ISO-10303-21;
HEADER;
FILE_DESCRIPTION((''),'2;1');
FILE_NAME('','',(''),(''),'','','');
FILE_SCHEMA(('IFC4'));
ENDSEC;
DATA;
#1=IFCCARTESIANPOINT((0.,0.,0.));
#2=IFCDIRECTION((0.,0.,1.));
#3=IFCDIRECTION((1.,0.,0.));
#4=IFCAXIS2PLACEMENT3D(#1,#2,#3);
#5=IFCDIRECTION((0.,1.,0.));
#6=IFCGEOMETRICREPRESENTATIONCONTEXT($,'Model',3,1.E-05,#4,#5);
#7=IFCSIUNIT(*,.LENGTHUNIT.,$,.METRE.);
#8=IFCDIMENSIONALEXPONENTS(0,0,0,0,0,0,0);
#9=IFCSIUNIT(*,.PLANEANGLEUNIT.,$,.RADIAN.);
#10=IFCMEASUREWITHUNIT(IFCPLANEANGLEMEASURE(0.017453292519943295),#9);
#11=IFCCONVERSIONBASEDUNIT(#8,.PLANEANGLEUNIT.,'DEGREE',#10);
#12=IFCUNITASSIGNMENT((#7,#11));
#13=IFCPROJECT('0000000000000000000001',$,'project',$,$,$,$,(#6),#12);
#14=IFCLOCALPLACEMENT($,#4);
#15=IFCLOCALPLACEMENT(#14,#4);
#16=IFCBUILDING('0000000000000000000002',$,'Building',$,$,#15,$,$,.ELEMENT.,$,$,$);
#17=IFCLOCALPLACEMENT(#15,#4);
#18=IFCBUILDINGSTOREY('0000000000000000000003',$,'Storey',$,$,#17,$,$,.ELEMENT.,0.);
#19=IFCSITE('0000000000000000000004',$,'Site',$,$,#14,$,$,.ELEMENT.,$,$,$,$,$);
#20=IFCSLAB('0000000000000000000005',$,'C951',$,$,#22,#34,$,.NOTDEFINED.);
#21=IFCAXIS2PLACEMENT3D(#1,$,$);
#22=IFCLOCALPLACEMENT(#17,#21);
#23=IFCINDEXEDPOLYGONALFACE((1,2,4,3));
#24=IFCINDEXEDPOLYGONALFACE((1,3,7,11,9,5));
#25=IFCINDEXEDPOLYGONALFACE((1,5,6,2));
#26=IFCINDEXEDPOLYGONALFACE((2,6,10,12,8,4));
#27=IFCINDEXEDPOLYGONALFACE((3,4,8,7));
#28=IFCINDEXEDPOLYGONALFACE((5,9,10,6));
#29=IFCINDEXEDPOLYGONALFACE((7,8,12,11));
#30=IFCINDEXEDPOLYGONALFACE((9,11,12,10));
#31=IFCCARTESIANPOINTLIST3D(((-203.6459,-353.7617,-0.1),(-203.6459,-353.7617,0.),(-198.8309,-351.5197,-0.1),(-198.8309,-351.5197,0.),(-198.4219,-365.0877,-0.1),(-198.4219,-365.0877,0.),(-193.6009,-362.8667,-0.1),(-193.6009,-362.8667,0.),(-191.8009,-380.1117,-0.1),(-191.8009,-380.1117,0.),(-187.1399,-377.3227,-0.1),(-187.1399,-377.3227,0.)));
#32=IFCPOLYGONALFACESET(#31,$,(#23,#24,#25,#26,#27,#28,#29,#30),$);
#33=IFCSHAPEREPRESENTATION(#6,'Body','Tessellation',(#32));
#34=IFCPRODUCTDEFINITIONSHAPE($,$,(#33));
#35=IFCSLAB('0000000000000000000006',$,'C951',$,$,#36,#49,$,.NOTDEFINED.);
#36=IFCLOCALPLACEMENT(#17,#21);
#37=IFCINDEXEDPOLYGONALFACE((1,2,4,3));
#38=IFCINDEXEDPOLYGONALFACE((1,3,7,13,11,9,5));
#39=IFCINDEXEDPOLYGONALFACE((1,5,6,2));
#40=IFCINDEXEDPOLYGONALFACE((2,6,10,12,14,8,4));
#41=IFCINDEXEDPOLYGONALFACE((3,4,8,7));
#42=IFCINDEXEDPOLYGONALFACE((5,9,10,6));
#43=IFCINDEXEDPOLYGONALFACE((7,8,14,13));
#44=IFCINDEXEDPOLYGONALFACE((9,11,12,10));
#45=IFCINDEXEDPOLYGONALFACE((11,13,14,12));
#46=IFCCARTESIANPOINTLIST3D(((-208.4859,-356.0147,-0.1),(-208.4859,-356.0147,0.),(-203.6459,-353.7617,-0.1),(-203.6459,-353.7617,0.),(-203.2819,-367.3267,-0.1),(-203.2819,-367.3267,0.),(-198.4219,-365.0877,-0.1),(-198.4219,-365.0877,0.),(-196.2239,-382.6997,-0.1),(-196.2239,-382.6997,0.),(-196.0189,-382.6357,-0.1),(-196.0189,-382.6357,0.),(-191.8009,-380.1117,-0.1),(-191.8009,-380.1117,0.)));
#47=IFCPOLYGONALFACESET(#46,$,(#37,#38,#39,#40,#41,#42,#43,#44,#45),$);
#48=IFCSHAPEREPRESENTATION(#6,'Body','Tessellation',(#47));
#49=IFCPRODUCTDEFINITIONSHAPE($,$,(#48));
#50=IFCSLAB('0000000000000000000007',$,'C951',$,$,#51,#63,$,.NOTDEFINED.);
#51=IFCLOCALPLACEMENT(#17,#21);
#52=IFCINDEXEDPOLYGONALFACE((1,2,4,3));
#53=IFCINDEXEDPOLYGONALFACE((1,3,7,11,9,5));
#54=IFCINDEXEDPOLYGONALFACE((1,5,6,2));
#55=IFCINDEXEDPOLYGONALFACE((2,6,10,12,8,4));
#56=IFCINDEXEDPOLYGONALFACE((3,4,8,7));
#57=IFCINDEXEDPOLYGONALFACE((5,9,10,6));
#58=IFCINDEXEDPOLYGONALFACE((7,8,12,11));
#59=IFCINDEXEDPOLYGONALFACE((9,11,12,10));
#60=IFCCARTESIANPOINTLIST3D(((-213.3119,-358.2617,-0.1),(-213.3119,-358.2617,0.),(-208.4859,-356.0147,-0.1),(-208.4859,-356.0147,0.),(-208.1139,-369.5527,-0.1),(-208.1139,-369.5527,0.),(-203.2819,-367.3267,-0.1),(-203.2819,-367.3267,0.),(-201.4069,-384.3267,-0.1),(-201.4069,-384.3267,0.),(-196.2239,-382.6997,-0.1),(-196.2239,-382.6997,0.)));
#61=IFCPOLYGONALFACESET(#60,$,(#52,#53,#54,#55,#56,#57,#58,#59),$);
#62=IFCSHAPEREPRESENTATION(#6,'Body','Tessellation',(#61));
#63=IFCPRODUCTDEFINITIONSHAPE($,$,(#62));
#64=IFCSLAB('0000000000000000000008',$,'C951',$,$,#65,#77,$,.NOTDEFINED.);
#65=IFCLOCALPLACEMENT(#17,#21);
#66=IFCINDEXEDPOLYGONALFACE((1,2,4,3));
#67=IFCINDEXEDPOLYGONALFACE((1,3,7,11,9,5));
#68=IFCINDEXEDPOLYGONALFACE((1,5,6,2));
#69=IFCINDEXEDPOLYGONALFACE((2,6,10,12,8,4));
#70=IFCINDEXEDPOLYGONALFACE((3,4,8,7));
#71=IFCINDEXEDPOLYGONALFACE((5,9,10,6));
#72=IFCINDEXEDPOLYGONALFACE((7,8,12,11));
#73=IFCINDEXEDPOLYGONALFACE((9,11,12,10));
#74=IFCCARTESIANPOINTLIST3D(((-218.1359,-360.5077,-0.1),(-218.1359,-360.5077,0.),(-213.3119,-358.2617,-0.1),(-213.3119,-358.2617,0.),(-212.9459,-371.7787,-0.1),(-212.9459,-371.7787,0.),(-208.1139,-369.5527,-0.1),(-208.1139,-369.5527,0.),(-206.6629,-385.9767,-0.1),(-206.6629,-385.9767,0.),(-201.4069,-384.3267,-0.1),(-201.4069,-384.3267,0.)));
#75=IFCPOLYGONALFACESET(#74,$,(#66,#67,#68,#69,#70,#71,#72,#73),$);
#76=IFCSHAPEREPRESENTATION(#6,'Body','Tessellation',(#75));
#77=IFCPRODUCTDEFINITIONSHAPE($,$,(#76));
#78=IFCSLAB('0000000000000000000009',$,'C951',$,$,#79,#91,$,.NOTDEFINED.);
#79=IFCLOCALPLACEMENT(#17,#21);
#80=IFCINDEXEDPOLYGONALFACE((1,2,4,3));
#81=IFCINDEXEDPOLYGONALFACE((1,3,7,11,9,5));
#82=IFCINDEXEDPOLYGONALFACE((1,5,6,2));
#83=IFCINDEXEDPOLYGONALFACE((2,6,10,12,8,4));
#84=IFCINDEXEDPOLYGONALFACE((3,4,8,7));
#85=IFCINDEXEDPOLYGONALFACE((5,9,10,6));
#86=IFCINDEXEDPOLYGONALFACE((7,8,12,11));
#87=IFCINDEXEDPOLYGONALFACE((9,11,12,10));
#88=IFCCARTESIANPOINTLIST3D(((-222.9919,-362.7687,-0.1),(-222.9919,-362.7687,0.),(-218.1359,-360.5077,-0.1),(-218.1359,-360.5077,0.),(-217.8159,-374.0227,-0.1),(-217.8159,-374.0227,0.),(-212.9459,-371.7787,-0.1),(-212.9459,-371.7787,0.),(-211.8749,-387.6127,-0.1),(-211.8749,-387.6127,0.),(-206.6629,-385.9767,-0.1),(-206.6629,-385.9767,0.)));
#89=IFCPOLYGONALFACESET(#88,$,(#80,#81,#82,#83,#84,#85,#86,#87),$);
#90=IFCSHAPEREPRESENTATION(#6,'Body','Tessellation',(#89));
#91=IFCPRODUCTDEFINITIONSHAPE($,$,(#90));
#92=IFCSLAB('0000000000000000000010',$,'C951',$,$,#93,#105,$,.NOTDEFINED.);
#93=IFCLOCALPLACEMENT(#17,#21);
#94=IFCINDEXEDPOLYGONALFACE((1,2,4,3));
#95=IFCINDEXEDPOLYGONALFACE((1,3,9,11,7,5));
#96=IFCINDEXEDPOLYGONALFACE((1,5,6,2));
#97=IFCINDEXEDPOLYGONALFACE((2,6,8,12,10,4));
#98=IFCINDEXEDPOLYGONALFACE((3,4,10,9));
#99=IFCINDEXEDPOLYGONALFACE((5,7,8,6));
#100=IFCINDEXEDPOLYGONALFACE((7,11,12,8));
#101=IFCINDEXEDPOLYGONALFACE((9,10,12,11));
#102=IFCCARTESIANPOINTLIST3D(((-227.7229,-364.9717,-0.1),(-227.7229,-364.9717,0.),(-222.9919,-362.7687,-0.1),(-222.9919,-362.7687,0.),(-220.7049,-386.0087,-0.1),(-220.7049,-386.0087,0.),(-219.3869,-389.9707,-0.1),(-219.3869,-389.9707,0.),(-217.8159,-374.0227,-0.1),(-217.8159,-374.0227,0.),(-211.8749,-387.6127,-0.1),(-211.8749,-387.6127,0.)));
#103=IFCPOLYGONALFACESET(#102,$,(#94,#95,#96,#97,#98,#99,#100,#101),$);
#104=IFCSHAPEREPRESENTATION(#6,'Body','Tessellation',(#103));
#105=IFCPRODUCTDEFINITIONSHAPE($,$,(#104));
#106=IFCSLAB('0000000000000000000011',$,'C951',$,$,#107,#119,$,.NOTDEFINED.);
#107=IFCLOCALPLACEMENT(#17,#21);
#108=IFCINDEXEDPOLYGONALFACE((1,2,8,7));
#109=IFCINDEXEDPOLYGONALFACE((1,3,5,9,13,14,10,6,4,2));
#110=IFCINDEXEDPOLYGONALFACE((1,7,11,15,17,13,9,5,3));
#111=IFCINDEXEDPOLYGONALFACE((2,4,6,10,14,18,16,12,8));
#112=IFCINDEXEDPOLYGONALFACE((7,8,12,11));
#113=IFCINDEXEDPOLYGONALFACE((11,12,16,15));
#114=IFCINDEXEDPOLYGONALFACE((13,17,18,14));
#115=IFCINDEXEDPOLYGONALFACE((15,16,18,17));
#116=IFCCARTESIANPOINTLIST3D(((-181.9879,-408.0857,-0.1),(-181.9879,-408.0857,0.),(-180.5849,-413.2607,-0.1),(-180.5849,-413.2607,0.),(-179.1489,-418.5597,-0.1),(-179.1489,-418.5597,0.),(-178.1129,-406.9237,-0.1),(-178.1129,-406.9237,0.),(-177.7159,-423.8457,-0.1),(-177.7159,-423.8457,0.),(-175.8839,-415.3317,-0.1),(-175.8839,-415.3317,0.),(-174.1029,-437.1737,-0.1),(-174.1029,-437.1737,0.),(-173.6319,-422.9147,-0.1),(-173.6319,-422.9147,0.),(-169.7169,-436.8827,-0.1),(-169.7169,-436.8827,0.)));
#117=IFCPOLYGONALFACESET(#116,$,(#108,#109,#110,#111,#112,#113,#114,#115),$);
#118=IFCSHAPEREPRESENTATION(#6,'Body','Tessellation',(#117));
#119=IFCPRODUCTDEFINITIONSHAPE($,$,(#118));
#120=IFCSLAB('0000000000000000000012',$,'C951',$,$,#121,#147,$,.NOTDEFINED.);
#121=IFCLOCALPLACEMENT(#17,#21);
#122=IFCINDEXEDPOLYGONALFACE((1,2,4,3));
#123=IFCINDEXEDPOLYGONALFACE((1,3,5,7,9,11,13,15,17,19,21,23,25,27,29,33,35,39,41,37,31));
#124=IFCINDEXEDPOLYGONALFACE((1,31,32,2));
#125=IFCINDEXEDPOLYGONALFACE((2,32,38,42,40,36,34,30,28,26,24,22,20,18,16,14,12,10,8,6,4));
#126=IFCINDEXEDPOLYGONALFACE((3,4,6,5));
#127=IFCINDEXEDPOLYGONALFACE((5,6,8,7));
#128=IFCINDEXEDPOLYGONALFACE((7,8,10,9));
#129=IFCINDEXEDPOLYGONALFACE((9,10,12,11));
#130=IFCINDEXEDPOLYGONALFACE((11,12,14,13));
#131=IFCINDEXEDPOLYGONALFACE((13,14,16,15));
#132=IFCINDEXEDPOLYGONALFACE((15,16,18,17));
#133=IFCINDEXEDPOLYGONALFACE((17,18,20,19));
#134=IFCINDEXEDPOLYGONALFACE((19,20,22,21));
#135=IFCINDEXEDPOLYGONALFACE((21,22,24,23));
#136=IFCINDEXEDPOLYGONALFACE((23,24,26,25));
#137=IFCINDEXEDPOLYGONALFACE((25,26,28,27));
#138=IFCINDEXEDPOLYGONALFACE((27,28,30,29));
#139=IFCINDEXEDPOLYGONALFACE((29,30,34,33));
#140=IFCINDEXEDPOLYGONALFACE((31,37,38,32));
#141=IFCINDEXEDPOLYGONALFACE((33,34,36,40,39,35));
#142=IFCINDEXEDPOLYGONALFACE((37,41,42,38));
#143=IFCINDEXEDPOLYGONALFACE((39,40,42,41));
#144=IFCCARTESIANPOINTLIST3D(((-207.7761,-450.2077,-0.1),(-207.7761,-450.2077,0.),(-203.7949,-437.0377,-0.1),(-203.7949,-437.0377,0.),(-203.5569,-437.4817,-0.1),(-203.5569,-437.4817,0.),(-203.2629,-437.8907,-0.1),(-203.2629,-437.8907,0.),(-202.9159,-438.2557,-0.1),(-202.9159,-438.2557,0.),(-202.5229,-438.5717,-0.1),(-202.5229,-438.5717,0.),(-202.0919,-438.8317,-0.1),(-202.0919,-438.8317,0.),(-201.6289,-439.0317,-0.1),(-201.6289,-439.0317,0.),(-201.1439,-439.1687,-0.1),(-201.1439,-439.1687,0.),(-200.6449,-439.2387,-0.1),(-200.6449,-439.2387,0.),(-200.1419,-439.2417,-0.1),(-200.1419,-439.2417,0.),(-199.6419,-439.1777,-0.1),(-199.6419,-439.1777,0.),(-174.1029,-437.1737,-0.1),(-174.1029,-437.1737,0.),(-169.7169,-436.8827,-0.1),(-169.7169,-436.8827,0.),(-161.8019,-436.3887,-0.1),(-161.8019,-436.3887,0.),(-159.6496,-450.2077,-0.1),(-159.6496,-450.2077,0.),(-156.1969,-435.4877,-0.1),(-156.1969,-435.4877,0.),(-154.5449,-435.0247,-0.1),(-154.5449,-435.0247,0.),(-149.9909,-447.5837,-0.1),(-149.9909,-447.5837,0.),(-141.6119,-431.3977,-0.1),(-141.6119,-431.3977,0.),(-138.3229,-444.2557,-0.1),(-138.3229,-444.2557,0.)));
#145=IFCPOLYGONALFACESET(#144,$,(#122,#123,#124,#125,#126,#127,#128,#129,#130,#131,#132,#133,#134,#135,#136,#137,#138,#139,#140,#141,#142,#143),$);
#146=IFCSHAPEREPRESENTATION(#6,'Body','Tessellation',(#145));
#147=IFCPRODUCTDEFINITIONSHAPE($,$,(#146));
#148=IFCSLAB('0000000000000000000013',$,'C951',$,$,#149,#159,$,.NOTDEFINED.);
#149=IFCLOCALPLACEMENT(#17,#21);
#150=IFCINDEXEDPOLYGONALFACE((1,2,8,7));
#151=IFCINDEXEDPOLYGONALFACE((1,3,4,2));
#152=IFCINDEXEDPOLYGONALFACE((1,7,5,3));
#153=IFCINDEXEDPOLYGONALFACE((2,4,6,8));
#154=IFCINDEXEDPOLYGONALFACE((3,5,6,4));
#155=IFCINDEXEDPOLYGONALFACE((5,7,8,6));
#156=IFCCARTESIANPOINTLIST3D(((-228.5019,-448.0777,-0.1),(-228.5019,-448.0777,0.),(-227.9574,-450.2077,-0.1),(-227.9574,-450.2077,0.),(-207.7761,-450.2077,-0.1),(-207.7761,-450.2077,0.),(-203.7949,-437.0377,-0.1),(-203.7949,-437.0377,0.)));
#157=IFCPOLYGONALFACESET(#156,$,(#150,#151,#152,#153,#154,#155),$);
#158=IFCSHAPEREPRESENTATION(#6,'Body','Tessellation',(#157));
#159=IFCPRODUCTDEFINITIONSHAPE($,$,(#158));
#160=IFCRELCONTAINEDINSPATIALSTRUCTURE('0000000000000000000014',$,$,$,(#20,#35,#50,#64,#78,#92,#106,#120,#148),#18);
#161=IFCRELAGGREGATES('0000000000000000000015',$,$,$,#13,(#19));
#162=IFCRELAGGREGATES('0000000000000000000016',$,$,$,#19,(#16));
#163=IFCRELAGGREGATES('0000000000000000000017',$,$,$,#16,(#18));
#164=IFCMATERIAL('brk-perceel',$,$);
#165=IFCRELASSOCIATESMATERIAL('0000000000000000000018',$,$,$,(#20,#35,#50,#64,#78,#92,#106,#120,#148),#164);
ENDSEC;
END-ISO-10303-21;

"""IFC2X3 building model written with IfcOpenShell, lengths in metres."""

from ifc_helpers import new_model, entity, si_unit, converted_unit, direction, frame, origin_with_axes, place, context, project, spatial, polyline, outline, extrude, material, element, save


model = new_model("IFC2X3")

# Units and contexts
model_context = context("Model", 3, precision=1e-05, world=origin_with_axes(), true_north=direction((0.0, 1.0, 0.0)))
ifc_project = project(units=[si_unit("LENGTHUNIT", "METRE"), converted_unit("PLANEANGLEUNIT", "DEGREE", entity("IfcPlaneAngleMeasure", 0.017453292519943295), si_unit("PLANEANGLEUNIT", "RADIAN"), dimensions=[0, 0, 0, 0, 0, 0, 0])], contexts=[model_context])

# Site, building, storey
site_placement = place(None, origin_with_axes())
site = spatial("IfcSite", under=ifc_project, at=site_placement, Name="Site", CompositionType="ELEMENT")
building_placement = place(site_placement, origin_with_axes())
building = spatial("IfcBuilding", under=site, at=building_placement, Name="Building", CompositionType="ELEMENT")
storey_placement = place(building_placement, origin_with_axes())
storey = spatial("IfcBuildingStorey", under=building, at=storey_placement, Name="Storey", CompositionType="ELEMENT", Elevation=0.0)

# Slabs
ifc_material = material(Name="brk-perceel")
slab_1_placement = place(storey_placement, frame((0.0, 0.0, -0.1), z_axis=(0.0, 0.0, 1.0), x_axis=(1.0, 0.0, 0.0)))
element("IfcSlab", 1, at=slab_1_placement, inside=storey, material=ifc_material, Name="C951", PredefinedType="NOTDEFINED", context=model_context, shape_type="SweptSolid", body=[
    extrude(outline(polyline([(-198.4219, -365.0877), (-203.6459, -353.7617), (-198.8309, -351.5197), (-193.6009, -362.8667), (-187.1399, -377.3227), (-191.8009, -380.1117), (-198.4219, -365.0877)])), origin_with_axes(), (0.0, 0.0, 1.0), 0.1),
])
slab_2_placement = place(storey_placement, frame((0.0, 0.0, -0.1), z_axis=(0.0, 0.0, 1.0), x_axis=(1.0, 0.0, 0.0)))
element("IfcSlab", 2, at=slab_2_placement, inside=storey, material=ifc_material, Name="C951", PredefinedType="NOTDEFINED", context=model_context, shape_type="SweptSolid", body=[
    extrude(outline(polyline([(-196.2239, -382.6997), (-203.2819, -367.3267), (-208.4859, -356.0147), (-203.6459, -353.7617), (-198.4219, -365.0877), (-191.8009, -380.1117), (-196.0189, -382.6357), (-196.2239, -382.6997)])), origin_with_axes(), (0.0, 0.0, 1.0), 0.1),
])
slab_3_placement = place(storey_placement, frame((0.0, 0.0, -0.1), z_axis=(0.0, 0.0, 1.0), x_axis=(1.0, 0.0, 0.0)))
element("IfcSlab", 3, at=slab_3_placement, inside=storey, material=ifc_material, Name="C951", PredefinedType="NOTDEFINED", context=model_context, shape_type="SweptSolid", body=[
    extrude(outline(polyline([(-201.4069, -384.3267), (-208.1139, -369.5527), (-213.3119, -358.2617), (-208.4859, -356.0147), (-203.2819, -367.3267), (-196.2239, -382.6997), (-201.4069, -384.3267)])), origin_with_axes(), (0.0, 0.0, 1.0), 0.1),
])
slab_4_placement = place(storey_placement, frame((0.0, 0.0, -0.1), z_axis=(0.0, 0.0, 1.0), x_axis=(1.0, 0.0, 0.0)))
element("IfcSlab", 4, at=slab_4_placement, inside=storey, material=ifc_material, Name="C951", PredefinedType="NOTDEFINED", context=model_context, shape_type="SweptSolid", body=[
    extrude(outline(polyline([(-206.6629, -385.9767), (-212.9459, -371.7787), (-218.1359, -360.5077), (-213.3119, -358.2617), (-208.1139, -369.5527), (-201.4069, -384.3267), (-206.6629, -385.9767)])), origin_with_axes(), (0.0, 0.0, 1.0), 0.1),
])
slab_5_placement = place(storey_placement, frame((0.0, 0.0, -0.1), z_axis=(0.0, 0.0, 1.0), x_axis=(1.0, 0.0, 0.0)))
element("IfcSlab", 5, at=slab_5_placement, inside=storey, material=ifc_material, Name="C951", PredefinedType="NOTDEFINED", context=model_context, shape_type="SweptSolid", body=[
    extrude(outline(polyline([(-218.1359, -360.5077), (-212.9459, -371.7787), (-206.6629, -385.9767), (-211.8749, -387.6127), (-217.8159, -374.0227), (-222.9919, -362.7687), (-218.1359, -360.5077)])), origin_with_axes(), (0.0, 0.0, 1.0), 0.1),
])
slab_6_placement = place(storey_placement, frame((0.0, 0.0, -0.1), z_axis=(0.0, 0.0, 1.0), x_axis=(1.0, 0.0, 0.0)))
element("IfcSlab", 6, at=slab_6_placement, inside=storey, material=ifc_material, Name="C951", PredefinedType="NOTDEFINED", context=model_context, shape_type="SweptSolid", body=[
    extrude(outline(polyline([(-219.3869, -389.9707), (-220.7049, -386.0087), (-227.7229, -364.9717), (-222.9919, -362.7687), (-217.8159, -374.0227), (-211.8749, -387.6127), (-219.3869, -389.9707)])), origin_with_axes(), (0.0, 0.0, 1.0), 0.1),
])
slab_7_placement = place(storey_placement, frame((0.0, 0.0, -0.1), z_axis=(0.0, 0.0, 1.0), x_axis=(1.0, 0.0, 0.0)))
element("IfcSlab", 7, at=slab_7_placement, inside=storey, material=ifc_material, Name="C951", PredefinedType="NOTDEFINED", context=model_context, shape_type="SweptSolid", body=[
    extrude(outline(polyline([(-173.6319, -422.9147), (-169.7169, -436.8827), (-174.1029, -437.1737), (-177.7159, -423.8457), (-179.1489, -418.5597), (-180.5849, -413.2607), (-181.9879, -408.0857), (-178.1129, -406.9237), (-175.8839, -415.3317), (-173.6319, -422.9147)])), origin_with_axes(), (0.0, 0.0, 1.0), 0.1),
])
slab_8_placement = place(storey_placement, frame((0.0, 0.0, -0.1), z_axis=(0.0, 0.0, 1.0), x_axis=(1.0, 0.0, 0.0)))
element("IfcSlab", 8, at=slab_8_placement, inside=storey, material=ifc_material, Name="C951", PredefinedType="NOTDEFINED", context=model_context, shape_type="SweptSolid", body=[
    extrude(outline(polyline([(-203.7949, -437.0377), (-203.5569, -437.4817), (-203.2629, -437.8907), (-202.9159, -438.2557), (-202.5229, -438.5717), (-202.0919, -438.8317), (-201.6289, -439.0317), (-201.1439, -439.1687), (-200.6449, -439.2387), (-200.1419, -439.2417), (-199.6419, -439.1777), (-174.1029, -437.1737), (-169.7169, -436.8827), (-161.8019, -436.3887), (-156.1969, -435.4877), (-154.5449, -435.0247), (-141.6119, -431.3977), (-138.3229, -444.2557), (-149.9909, -447.5837), (-159.6496, -450.2077), (-207.7761, -450.2077), (-203.7949, -437.0377)])), origin_with_axes(), (0.0, 0.0, 1.0), 0.1),
])
slab_9_placement = place(storey_placement, frame((0.0, 0.0, -0.1), z_axis=(0.0, 0.0, 1.0), x_axis=(1.0, 0.0, 0.0)))
element("IfcSlab", 9, at=slab_9_placement, inside=storey, material=ifc_material, Name="C951", PredefinedType="NOTDEFINED", context=model_context, shape_type="SweptSolid", body=[
    extrude(outline(polyline([(-228.5019, -448.0777), (-203.7949, -437.0377), (-207.7761, -450.2077), (-227.9574, -450.2077), (-228.5019, -448.0777)])), origin_with_axes(), (0.0, 0.0, 1.0), 0.1),
])

save(model, "model.ifc")
